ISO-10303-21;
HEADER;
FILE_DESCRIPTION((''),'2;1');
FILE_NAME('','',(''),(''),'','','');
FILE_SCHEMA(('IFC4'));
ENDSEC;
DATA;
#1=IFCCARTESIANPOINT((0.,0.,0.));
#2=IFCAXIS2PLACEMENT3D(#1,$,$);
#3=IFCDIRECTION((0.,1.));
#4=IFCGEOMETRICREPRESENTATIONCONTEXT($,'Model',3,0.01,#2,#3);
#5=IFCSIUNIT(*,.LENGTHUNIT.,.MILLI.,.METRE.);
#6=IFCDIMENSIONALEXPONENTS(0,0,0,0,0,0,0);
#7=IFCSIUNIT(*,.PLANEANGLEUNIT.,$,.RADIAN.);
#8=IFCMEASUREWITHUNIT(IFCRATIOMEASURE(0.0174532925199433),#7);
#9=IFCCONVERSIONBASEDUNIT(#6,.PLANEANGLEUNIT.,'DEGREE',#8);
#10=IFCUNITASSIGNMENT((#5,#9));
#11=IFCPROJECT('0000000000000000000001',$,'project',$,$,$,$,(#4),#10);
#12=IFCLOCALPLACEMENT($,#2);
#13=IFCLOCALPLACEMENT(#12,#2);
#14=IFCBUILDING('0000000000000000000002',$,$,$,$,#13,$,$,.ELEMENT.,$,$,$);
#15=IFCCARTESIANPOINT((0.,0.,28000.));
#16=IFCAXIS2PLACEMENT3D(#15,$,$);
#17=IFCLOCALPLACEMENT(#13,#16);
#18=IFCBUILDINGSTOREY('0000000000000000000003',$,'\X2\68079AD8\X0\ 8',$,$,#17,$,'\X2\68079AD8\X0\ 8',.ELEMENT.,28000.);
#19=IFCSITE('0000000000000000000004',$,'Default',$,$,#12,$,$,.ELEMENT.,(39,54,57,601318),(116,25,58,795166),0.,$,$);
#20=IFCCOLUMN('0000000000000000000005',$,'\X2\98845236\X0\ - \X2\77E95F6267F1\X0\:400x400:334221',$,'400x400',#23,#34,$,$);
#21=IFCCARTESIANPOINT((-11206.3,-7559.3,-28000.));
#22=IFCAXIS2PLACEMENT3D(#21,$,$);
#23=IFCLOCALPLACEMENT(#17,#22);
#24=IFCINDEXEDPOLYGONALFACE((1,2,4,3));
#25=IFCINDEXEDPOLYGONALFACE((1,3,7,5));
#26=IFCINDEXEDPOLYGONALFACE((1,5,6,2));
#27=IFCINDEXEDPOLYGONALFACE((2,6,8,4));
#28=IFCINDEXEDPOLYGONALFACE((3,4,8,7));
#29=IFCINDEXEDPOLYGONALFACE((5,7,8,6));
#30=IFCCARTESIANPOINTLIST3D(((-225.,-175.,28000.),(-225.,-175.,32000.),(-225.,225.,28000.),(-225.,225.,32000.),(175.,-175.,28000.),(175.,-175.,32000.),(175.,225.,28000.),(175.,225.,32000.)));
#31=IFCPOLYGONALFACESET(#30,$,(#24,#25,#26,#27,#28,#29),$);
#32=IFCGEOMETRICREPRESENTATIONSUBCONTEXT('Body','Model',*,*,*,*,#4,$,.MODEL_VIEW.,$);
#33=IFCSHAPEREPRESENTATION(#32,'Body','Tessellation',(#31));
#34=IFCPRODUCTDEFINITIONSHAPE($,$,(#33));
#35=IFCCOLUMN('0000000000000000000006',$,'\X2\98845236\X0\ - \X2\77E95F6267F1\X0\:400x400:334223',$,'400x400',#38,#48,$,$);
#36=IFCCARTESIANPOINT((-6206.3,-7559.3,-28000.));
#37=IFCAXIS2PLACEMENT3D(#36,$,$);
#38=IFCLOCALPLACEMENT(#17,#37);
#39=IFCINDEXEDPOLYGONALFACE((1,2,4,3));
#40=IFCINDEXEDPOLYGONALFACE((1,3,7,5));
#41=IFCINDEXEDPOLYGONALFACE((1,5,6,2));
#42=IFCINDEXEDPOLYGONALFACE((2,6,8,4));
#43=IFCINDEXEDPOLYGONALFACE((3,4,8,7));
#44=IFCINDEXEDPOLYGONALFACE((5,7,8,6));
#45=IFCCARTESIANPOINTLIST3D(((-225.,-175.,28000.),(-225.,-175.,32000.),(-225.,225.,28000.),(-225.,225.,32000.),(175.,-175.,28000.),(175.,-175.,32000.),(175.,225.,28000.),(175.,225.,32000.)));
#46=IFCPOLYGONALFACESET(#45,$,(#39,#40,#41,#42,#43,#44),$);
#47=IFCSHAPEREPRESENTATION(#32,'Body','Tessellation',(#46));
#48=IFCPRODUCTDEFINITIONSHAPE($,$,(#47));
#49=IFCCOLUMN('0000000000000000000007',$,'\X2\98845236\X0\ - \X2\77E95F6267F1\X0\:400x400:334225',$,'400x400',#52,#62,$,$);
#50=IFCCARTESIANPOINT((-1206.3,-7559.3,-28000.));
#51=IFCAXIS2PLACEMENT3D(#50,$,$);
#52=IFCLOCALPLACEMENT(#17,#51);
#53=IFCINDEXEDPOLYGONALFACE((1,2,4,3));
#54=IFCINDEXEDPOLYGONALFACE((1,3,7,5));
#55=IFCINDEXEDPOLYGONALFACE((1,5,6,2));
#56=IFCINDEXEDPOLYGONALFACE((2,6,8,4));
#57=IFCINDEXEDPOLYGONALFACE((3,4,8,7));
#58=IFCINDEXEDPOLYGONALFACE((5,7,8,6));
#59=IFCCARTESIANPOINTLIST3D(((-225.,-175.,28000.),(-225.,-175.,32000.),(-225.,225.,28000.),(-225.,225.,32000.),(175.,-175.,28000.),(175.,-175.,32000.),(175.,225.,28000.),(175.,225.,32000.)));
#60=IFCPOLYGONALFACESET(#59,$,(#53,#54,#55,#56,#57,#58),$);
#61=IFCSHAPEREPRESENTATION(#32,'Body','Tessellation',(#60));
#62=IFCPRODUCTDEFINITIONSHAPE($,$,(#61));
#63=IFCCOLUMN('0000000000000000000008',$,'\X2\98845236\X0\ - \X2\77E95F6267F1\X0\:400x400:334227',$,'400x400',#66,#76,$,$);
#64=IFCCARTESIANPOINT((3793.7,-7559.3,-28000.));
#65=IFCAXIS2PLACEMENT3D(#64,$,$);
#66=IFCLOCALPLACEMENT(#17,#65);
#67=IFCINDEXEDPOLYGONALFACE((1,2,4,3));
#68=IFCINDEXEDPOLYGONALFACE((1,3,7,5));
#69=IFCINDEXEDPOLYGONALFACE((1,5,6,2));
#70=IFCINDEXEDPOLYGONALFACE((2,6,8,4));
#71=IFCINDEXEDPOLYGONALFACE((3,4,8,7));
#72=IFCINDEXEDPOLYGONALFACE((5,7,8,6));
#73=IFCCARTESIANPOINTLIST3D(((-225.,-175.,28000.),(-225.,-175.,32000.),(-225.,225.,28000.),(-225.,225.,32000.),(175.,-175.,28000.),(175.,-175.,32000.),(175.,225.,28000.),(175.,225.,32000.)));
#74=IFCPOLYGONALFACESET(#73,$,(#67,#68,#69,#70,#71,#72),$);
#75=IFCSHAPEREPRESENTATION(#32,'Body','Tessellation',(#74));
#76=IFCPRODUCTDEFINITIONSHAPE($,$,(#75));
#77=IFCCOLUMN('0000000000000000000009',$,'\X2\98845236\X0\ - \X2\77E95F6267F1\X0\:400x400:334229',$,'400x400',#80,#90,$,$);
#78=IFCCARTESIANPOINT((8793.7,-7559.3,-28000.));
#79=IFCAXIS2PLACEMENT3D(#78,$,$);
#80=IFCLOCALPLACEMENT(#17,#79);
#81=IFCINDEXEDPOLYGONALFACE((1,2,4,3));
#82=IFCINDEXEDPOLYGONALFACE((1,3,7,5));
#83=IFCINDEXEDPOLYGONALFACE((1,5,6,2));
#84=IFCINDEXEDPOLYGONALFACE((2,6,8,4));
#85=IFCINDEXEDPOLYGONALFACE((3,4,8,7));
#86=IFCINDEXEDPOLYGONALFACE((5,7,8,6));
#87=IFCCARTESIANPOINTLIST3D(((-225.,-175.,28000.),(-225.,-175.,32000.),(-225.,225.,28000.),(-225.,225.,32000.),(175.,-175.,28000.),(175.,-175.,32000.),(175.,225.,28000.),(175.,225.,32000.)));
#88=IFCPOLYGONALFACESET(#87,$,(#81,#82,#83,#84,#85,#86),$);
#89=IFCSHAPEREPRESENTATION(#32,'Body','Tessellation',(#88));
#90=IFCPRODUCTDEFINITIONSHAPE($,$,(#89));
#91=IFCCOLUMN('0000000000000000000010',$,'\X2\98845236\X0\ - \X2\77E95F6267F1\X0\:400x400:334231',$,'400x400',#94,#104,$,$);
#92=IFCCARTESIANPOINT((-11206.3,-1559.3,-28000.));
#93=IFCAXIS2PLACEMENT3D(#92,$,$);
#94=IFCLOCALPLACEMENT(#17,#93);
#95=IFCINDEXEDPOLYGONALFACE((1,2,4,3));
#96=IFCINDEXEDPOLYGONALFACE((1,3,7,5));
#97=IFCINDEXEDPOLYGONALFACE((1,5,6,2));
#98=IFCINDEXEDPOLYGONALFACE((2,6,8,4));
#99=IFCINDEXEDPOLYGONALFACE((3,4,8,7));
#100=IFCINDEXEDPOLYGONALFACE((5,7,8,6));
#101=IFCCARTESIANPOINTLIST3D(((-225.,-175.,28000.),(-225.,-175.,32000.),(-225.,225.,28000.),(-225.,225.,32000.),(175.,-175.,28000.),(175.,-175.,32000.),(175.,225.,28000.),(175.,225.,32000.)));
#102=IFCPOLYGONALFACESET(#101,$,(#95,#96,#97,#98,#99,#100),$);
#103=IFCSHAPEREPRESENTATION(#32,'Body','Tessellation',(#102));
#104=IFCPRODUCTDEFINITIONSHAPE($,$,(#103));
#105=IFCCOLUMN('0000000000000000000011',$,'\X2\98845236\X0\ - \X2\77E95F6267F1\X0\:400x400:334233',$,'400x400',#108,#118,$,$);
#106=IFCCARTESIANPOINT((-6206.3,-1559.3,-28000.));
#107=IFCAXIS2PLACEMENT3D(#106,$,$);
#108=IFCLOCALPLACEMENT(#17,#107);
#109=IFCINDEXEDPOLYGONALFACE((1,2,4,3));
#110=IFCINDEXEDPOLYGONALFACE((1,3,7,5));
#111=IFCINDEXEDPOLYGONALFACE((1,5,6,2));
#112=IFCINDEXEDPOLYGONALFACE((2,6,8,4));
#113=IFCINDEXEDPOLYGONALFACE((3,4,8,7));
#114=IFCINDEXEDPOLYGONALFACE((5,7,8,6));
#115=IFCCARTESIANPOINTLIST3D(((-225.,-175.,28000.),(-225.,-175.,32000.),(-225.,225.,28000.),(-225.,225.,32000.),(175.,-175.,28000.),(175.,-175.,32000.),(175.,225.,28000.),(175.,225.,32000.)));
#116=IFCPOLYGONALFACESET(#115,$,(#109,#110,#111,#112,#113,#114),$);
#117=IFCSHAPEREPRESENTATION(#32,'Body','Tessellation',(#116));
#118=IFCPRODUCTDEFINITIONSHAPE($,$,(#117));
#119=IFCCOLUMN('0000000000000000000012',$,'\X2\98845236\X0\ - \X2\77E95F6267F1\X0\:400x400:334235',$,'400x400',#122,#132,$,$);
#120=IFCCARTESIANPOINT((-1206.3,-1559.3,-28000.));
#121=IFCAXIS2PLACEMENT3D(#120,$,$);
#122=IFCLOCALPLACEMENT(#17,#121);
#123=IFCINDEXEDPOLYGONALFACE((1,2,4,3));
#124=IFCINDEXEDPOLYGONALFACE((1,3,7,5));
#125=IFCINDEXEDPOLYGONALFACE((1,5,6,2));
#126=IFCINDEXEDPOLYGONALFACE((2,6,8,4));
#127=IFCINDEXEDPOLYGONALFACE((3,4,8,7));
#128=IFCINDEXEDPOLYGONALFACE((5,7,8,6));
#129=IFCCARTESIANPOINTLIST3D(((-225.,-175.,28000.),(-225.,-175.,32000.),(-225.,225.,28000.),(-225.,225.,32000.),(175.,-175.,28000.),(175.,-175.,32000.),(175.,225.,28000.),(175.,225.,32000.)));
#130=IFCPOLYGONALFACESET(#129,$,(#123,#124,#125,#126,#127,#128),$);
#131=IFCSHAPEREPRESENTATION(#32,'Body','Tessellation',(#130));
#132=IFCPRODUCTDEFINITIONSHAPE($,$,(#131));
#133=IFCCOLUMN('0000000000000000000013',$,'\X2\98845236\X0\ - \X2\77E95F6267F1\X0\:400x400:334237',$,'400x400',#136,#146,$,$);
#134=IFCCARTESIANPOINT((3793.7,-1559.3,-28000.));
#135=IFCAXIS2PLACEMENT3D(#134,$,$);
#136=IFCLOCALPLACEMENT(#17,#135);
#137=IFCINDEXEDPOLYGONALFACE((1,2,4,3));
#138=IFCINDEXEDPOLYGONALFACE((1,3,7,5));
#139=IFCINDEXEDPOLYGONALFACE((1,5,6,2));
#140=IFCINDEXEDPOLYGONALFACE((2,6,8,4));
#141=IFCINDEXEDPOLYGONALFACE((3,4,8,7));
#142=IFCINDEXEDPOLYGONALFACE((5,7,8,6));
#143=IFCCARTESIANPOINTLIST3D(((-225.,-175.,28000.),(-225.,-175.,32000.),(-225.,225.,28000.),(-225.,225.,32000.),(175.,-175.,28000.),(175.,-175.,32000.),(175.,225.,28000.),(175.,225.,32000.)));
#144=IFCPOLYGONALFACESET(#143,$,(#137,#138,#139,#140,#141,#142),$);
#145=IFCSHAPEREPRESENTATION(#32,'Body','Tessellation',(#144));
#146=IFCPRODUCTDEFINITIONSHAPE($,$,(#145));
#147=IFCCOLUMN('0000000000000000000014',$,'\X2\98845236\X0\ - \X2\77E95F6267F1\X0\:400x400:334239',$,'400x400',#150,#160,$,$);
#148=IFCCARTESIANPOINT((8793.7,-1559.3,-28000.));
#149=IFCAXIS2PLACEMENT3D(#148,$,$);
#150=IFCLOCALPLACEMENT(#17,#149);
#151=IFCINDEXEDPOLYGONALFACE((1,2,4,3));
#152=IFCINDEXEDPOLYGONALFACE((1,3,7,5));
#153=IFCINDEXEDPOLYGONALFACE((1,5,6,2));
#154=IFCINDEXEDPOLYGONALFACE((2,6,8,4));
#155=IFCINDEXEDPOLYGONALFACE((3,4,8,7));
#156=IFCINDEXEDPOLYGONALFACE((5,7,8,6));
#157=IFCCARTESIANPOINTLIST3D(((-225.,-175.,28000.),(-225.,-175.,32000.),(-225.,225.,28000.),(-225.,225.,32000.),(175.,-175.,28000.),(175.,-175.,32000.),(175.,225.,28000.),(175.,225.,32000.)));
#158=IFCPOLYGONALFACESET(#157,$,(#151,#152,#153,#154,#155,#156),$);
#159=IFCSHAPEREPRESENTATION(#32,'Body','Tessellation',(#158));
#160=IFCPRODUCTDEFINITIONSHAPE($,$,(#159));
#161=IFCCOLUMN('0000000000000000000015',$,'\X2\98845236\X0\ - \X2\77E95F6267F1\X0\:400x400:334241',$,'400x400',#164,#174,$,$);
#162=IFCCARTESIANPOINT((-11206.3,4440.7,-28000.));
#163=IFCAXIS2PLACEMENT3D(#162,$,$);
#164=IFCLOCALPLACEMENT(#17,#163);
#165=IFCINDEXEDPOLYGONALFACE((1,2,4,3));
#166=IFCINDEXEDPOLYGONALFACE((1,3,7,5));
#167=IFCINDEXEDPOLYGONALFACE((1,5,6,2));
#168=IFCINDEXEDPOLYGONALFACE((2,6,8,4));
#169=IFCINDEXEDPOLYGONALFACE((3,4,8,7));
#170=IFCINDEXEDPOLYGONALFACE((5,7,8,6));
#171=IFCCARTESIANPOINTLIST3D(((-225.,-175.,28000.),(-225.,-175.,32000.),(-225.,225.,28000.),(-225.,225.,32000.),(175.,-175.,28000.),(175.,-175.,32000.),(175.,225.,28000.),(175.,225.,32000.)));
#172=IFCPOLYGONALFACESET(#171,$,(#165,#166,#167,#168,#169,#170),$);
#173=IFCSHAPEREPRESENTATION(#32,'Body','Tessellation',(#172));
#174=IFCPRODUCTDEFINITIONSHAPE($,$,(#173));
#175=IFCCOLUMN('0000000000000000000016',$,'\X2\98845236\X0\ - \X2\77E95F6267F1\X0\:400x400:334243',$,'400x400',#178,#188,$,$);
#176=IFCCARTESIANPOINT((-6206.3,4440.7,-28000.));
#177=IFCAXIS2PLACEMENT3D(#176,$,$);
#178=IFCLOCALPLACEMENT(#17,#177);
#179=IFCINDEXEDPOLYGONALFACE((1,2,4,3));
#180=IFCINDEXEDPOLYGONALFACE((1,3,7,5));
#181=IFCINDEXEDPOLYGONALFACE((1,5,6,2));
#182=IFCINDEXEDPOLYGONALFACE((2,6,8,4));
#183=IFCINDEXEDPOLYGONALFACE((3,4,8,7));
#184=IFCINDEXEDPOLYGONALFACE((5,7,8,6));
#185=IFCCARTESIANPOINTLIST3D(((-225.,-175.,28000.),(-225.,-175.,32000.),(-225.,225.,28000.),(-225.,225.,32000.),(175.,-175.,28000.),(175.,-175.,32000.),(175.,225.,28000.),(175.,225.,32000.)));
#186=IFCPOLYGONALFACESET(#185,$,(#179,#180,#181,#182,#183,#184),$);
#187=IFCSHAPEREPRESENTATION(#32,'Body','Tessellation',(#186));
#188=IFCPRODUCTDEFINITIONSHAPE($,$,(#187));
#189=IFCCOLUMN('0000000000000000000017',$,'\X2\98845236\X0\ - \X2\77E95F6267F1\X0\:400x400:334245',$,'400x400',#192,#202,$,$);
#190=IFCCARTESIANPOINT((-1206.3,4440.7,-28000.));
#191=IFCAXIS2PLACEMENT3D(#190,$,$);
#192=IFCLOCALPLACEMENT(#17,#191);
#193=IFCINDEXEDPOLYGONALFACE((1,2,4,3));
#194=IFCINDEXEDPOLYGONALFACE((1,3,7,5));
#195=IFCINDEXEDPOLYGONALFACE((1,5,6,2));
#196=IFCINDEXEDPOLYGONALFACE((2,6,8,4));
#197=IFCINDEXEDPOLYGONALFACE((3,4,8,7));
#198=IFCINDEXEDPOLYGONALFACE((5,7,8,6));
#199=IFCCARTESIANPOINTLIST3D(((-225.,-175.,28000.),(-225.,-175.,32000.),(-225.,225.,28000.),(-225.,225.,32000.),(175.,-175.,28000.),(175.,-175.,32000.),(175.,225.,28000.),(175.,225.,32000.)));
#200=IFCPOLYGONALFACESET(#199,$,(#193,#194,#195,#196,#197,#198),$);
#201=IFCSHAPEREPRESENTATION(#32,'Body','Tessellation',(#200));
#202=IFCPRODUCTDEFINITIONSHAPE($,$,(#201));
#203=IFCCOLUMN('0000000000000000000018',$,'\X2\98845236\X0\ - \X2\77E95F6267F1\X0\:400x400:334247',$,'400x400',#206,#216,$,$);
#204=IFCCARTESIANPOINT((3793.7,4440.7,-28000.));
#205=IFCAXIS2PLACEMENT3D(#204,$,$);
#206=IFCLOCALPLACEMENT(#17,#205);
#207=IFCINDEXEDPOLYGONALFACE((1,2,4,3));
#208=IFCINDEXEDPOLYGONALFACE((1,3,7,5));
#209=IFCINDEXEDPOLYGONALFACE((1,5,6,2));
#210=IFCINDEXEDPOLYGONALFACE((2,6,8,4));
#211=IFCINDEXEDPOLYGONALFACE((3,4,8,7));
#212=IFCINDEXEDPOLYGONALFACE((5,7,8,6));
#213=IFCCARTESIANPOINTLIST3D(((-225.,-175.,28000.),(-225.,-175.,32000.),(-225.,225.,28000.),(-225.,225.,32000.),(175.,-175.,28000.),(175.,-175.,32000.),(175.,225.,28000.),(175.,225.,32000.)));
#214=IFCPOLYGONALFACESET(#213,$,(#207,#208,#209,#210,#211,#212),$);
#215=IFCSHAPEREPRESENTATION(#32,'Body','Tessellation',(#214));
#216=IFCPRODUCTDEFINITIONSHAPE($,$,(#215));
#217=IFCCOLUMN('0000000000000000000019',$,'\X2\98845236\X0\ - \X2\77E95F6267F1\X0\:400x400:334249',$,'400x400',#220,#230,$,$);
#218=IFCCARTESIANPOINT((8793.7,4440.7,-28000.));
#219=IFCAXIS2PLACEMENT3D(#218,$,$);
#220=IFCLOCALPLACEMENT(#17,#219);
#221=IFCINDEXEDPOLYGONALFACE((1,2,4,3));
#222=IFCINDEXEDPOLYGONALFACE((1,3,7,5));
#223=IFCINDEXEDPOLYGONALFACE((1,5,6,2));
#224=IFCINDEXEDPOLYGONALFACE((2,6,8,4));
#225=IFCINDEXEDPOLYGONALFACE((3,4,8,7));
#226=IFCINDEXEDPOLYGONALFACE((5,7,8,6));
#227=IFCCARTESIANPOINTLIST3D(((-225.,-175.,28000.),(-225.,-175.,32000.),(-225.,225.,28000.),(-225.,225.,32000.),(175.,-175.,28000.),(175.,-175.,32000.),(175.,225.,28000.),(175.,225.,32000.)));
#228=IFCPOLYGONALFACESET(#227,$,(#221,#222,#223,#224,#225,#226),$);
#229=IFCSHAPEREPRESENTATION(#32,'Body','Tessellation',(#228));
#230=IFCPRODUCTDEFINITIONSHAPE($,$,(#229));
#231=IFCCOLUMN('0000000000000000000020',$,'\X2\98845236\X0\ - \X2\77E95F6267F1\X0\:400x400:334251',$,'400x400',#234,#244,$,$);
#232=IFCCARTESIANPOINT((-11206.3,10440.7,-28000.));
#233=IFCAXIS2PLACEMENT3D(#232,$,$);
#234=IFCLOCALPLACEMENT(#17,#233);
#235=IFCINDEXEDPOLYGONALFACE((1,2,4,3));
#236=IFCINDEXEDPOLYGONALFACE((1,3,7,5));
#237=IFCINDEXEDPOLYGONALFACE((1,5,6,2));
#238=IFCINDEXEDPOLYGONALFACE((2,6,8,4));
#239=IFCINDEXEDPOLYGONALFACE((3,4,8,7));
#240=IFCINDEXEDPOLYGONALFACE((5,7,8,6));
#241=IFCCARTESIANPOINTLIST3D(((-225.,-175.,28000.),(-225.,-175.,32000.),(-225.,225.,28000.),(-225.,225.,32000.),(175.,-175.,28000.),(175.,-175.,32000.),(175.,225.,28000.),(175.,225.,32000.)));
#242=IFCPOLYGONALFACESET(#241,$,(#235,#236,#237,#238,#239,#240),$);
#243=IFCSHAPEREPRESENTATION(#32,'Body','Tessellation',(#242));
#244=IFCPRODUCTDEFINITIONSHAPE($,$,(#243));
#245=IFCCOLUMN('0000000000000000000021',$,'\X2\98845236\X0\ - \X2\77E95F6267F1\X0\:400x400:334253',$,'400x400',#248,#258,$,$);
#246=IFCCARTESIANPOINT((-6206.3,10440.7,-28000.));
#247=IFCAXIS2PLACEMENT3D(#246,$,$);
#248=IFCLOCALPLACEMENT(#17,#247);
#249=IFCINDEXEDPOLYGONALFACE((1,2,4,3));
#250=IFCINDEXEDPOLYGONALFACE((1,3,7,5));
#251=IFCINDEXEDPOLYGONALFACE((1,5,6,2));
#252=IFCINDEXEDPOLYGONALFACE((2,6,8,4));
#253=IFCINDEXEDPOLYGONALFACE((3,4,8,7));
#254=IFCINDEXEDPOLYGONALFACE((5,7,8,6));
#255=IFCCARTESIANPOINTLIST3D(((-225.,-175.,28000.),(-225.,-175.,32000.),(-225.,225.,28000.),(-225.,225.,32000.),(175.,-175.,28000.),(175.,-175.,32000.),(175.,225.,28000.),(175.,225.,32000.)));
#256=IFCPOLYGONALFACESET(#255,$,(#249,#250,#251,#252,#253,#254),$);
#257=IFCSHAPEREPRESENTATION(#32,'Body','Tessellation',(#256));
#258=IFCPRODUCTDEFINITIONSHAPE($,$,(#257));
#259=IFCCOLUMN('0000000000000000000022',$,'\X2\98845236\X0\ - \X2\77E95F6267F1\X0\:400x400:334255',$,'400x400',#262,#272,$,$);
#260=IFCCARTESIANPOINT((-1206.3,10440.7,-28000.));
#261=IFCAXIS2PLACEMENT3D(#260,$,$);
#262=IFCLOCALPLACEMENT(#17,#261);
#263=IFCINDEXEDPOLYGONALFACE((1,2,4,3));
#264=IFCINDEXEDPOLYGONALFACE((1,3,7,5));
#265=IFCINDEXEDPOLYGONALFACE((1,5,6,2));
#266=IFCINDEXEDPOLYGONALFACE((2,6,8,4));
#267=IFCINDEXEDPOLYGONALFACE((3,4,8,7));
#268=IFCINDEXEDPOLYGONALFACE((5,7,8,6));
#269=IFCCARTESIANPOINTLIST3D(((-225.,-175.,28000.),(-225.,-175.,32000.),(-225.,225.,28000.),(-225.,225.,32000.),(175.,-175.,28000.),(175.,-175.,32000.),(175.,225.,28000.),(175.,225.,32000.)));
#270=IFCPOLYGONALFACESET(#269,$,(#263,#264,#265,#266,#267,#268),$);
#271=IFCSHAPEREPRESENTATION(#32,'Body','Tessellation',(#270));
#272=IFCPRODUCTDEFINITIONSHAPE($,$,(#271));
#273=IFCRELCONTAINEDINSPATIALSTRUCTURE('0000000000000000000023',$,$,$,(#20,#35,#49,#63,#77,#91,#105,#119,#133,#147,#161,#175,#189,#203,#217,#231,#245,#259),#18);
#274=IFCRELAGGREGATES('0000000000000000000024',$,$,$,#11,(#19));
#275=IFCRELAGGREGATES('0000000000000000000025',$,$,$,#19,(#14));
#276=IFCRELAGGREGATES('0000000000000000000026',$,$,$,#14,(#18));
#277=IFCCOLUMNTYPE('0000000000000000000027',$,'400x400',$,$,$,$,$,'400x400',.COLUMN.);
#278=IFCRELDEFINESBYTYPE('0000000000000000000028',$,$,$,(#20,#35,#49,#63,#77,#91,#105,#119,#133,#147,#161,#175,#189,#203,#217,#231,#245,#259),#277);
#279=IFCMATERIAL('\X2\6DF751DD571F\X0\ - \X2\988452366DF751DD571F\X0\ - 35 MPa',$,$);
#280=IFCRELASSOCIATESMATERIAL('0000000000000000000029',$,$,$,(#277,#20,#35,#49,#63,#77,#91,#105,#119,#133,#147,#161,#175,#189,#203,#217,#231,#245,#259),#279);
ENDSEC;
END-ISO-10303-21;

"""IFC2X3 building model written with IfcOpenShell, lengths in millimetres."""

from ifc_helpers import new_model, entity, si_unit, converted_unit, direction, frame, frame_2d, origin, place, context, subcontext, project, spatial, rectangle, extrude, source, transform, mapped, material, type_object, type_shapes, element, save


model = new_model("IFC2X3")

# Units and contexts
model_context = context("Model", 3, precision=0.01, world=origin(), true_north=direction((0.0, 1.0)))
body_context = subcontext(model_context, "Body", "Model", "MODEL_VIEW")
ifc_project = project(units=[si_unit("LENGTHUNIT", "METRE", prefix="MILLI"), converted_unit("PLANEANGLEUNIT", "DEGREE", entity("IfcRatioMeasure", 0.0174532925199433), si_unit("PLANEANGLEUNIT", "RADIAN"), dimensions=[0, 0, 0, 0, 0, 0, 0])], contexts=[model_context])

# Site, building, storey
site_placement = place(None, origin())
site = spatial("IfcSite", under=ifc_project, at=site_placement, Name="Default", CompositionType="ELEMENT", RefLatitude=(39, 54, 57, 601318), RefLongitude=(116, 25, 58, 795166), RefElevation=0.0)
building_placement = place(site_placement, origin())
building = spatial("IfcBuilding", under=site, at=building_placement, CompositionType="ELEMENT")
storey_placement = place(building_placement, frame((0.0, 0.0, 28000.0)))
storey = spatial("IfcBuildingStorey", under=building, at=storey_placement, Name="标高 8", LongName="标高 8", CompositionType="ELEMENT", Elevation=28000.0)

# Columns
ifc_material = material(Name="混凝土 - 预制混凝土 - 35 MPa")
column_type = type_object("IfcColumnType", Name="400x400", ElementType="400x400", PredefinedType="COLUMN", material=ifc_material)
shared_shape = source(origin(), body_context, "Body", "SweptSolid", [
    extrude(rectangle(XDim=400.0, YDim=400.0, at=frame_2d((0.0, 0.0), x_axis=(1.0, 0.0))), frame((-25.0, 25.0, 28000.0)), (0.0, 0.0, 1.0), 4000.0),
])
type_shapes(column_type, [shared_shape])
for number, where, name in (
    (1, (-11206.3, -7559.3, -28000.0), "预制 - 矩形柱:400x400:334221"),
    (2, (-6206.3, -7559.3, -28000.0), "预制 - 矩形柱:400x400:334223"),
    (3, (-1206.3, -7559.3, -28000.0), "预制 - 矩形柱:400x400:334225"),
    (4, (3793.7, -7559.3, -28000.0), "预制 - 矩形柱:400x400:334227"),
    (5, (8793.7, -7559.3, -28000.0), "预制 - 矩形柱:400x400:334229"),
    (6, (-11206.3, -1559.3, -28000.0), "预制 - 矩形柱:400x400:334231"),
    (7, (-6206.3, -1559.3, -28000.0), "预制 - 矩形柱:400x400:334233"),
    (8, (-1206.3, -1559.3, -28000.0), "预制 - 矩形柱:400x400:334235"),
    (9, (3793.7, -1559.3, -28000.0), "预制 - 矩形柱:400x400:334237"),
    (10, (8793.7, -1559.3, -28000.0), "预制 - 矩形柱:400x400:334239"),
    (11, (-11206.3, 4440.7, -28000.0), "预制 - 矩形柱:400x400:334241"),
    (12, (-6206.3, 4440.7, -28000.0), "预制 - 矩形柱:400x400:334243"),
    (13, (-1206.3, 4440.7, -28000.0), "预制 - 矩形柱:400x400:334245"),
    (14, (3793.7, 4440.7, -28000.0), "预制 - 矩形柱:400x400:334247"),
    (15, (8793.7, 4440.7, -28000.0), "预制 - 矩形柱:400x400:334249"),
    (16, (-11206.3, 10440.7, -28000.0), "预制 - 矩形柱:400x400:334251"),
    (17, (-6206.3, 10440.7, -28000.0), "预制 - 矩形柱:400x400:334253"),
    (18, (-1206.3, 10440.7, -28000.0), "预制 - 矩形柱:400x400:334255"),
):
    element("IfcColumn", number, at=place(storey_placement, frame(where)), inside=storey, type_object=column_type, material=ifc_material, Name=name, ObjectType="400x400", context=body_context, shape_type="MappedRepresentation", body=[
        mapped(shared_shape, transform((0.0, 0.0, 0.0), scale=1.0)),
    ])

save(model, "model.ifc")
